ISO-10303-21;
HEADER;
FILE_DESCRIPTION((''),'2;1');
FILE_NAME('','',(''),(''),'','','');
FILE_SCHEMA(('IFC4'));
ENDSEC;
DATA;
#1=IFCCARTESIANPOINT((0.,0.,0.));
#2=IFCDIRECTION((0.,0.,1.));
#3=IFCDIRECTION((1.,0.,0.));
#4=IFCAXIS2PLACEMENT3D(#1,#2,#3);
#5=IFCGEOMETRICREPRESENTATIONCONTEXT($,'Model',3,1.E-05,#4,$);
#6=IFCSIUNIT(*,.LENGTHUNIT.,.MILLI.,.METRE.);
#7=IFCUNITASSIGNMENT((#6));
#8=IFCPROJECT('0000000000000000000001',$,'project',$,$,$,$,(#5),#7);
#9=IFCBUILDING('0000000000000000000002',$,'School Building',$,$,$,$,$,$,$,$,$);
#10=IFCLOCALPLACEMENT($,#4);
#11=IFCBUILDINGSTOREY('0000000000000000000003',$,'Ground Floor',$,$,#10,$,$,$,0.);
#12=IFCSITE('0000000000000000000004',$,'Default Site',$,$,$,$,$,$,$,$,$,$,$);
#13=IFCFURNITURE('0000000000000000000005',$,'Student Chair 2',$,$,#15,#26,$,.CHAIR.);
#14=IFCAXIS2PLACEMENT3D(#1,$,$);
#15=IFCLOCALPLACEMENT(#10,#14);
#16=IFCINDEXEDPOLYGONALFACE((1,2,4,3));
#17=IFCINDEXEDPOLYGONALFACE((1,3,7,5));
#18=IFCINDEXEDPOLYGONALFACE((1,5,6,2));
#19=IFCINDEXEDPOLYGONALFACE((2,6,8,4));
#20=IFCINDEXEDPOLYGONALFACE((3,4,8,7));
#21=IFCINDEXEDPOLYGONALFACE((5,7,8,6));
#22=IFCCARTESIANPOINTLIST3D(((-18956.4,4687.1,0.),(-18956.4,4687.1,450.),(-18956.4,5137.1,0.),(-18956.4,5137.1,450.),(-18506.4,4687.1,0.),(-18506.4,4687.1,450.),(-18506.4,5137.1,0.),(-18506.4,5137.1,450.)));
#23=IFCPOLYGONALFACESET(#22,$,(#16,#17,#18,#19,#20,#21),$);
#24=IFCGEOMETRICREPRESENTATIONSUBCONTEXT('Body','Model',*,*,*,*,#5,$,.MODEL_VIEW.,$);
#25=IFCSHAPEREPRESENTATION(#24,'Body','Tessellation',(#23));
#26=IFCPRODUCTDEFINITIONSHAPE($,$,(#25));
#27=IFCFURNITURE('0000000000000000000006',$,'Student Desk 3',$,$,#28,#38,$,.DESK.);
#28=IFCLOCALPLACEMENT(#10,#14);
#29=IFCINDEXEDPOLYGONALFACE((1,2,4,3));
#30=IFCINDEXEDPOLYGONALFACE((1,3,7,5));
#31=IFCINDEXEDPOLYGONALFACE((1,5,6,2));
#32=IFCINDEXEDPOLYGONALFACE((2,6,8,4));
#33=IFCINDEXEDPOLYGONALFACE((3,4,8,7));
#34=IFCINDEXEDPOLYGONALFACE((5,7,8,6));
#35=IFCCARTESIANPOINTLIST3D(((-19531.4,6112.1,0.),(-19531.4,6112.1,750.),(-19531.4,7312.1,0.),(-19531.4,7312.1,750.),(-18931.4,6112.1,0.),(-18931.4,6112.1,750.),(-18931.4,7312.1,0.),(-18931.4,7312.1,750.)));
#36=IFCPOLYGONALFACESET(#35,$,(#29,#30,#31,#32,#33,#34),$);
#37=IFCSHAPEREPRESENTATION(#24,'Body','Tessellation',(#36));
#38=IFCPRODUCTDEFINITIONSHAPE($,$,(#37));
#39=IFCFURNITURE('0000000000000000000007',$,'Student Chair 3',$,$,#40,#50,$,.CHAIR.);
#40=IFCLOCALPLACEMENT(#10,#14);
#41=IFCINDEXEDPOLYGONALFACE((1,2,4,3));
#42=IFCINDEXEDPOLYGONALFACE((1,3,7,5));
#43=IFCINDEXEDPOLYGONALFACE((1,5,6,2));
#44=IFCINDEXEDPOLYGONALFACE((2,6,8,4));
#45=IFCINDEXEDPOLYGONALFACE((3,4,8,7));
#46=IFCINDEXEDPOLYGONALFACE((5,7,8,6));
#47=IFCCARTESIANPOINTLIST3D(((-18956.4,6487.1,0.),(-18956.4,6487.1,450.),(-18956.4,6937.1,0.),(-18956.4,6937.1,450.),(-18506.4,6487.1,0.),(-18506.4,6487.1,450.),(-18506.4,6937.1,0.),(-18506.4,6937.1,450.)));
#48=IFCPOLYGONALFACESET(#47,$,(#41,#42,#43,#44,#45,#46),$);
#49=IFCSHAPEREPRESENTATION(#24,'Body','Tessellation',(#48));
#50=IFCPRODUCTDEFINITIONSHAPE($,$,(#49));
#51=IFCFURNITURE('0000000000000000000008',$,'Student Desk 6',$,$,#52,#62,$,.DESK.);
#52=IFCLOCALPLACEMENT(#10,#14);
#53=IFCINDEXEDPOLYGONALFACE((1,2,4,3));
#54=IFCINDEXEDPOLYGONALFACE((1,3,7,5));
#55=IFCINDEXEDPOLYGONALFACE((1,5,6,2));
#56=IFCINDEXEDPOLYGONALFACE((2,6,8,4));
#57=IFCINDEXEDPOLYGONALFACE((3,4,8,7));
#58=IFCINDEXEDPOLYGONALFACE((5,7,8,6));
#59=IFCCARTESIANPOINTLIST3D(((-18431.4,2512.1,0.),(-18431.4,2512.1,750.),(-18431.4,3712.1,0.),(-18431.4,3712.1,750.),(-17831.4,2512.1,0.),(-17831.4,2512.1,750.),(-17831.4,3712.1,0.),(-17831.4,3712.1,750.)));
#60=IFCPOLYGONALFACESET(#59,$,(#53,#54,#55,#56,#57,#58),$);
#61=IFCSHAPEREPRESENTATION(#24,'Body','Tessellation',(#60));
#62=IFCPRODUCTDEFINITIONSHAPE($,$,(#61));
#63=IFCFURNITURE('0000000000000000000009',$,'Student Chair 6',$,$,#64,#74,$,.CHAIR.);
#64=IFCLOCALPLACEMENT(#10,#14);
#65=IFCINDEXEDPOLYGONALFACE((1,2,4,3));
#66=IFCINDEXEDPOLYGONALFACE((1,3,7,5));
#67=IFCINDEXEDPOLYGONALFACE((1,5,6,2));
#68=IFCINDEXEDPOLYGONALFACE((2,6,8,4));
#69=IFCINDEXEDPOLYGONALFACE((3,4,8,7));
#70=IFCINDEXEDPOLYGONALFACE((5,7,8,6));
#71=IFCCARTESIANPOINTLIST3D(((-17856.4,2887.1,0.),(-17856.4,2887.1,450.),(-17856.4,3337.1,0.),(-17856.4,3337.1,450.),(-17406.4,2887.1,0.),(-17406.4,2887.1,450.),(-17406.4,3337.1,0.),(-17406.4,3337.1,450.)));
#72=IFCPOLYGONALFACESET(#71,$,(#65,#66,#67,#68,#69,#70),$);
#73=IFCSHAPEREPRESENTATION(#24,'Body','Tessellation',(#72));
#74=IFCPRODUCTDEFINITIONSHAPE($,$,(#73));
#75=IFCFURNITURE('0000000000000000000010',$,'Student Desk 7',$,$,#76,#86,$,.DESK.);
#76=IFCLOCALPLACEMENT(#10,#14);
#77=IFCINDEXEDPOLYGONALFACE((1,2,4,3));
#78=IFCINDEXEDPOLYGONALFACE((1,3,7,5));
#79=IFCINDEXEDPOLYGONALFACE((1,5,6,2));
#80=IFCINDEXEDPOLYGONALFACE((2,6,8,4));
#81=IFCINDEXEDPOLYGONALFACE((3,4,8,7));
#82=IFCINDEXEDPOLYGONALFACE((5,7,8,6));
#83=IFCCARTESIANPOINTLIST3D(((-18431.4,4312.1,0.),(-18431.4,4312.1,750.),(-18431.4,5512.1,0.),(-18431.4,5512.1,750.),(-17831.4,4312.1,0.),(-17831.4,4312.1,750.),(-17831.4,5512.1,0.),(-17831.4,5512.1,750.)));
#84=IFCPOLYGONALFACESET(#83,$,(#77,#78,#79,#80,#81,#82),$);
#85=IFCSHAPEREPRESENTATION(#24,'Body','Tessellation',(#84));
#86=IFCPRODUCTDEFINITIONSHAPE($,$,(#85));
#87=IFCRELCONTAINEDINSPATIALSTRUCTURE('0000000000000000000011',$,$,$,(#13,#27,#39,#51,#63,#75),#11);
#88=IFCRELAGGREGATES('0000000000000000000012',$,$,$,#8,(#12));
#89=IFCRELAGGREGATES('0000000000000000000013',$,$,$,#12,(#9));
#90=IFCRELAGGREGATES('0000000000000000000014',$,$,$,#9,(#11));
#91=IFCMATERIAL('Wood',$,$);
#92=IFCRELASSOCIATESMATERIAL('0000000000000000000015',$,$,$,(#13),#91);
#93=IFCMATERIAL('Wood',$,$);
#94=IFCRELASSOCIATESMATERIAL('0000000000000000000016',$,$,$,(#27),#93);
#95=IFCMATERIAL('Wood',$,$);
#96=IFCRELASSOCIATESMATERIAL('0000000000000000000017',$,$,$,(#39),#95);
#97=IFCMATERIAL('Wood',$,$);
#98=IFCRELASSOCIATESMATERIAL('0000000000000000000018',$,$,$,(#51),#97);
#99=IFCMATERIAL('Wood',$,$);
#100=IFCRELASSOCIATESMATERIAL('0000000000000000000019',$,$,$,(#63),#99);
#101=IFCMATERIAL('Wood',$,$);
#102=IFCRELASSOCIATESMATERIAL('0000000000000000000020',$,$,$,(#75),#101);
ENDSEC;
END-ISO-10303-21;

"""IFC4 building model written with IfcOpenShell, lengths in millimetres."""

from ifc_helpers import new_model, si_unit, frame, origin_with_axes, origin_2d, place, context, subcontext, project, spatial, rectangle, extrude, material, element, save


model = new_model("IFC4")

# Units and contexts
model_context = context("Model", 3, precision=1e-05, world=origin_with_axes())
body_context = subcontext(model_context, "Body", "Model", "MODEL_VIEW")
ifc_project = project(units=[si_unit("LENGTHUNIT", "METRE", prefix="MILLI")], contexts=[model_context])

# Site, building, storey
site = spatial("IfcSite", under=ifc_project, Name="Default Site")
building = spatial("IfcBuilding", under=site, Name="School Building")
storey_placement = place(None, origin_with_axes())
storey = spatial("IfcBuildingStorey", under=building, at=storey_placement, Name="Ground Floor", Elevation=0.0)

# Furniture
ifc_material_1 = material(Name="Wood")
furniture_1_placement = place(storey_placement, frame((-18731.4, 4912.1, 0.0), z_axis=(0.0, 0.0, 1.0), x_axis=(1.0, 0.0, 0.0)))
element("IfcFurniture", 1, at=furniture_1_placement, inside=storey, material=ifc_material_1, Name="Student Chair 2", PredefinedType="CHAIR", context=body_context, shape_type="SweptSolid", body=[
    extrude(rectangle(XDim=450.0, YDim=450.0, at=origin_2d()), origin_with_axes(), (0.0, 0.0, 1.0), 450.0),
])
ifc_material_2 = material(Name="Wood")
furniture_2_placement = place(storey_placement, frame((-19231.4, 6712.1, 0.0), z_axis=(0.0, 0.0, 1.0), x_axis=(0.0, 1.0, 0.0)))
element("IfcFurniture", 2, at=furniture_2_placement, inside=storey, material=ifc_material_2, Name="Student Desk 3", PredefinedType="DESK", context=body_context, shape_type="SweptSolid", body=[
    extrude(rectangle(XDim=1200.0, YDim=600.0, at=origin_2d()), origin_with_axes(), (0.0, 0.0, 1.0), 750.0),
])
ifc_material_3 = material(Name="Wood")
furniture_3_placement = place(storey_placement, frame((-18731.4, 6712.1, 0.0), z_axis=(0.0, 0.0, 1.0), x_axis=(1.0, 0.0, 0.0)))
element("IfcFurniture", 3, at=furniture_3_placement, inside=storey, material=ifc_material_3, Name="Student Chair 3", PredefinedType="CHAIR", context=body_context, shape_type="SweptSolid", body=[
    extrude(rectangle(XDim=450.0, YDim=450.0, at=origin_2d()), origin_with_axes(), (0.0, 0.0, 1.0), 450.0),
])
ifc_material_4 = material(Name="Wood")
furniture_4_placement = place(storey_placement, frame((-18131.4, 3112.1, 0.0), z_axis=(0.0, 0.0, 1.0), x_axis=(0.0, 1.0, 0.0)))
element("IfcFurniture", 4, at=furniture_4_placement, inside=storey, material=ifc_material_4, Name="Student Desk 6", PredefinedType="DESK", context=body_context, shape_type="SweptSolid", body=[
    extrude(rectangle(XDim=1200.0, YDim=600.0, at=origin_2d()), origin_with_axes(), (0.0, 0.0, 1.0), 750.0),
])
ifc_material_5 = material(Name="Wood")
furniture_5_placement = place(storey_placement, frame((-17631.4, 3112.1, 0.0), z_axis=(0.0, 0.0, 1.0), x_axis=(1.0, 0.0, 0.0)))
element("IfcFurniture", 5, at=furniture_5_placement, inside=storey, material=ifc_material_5, Name="Student Chair 6", PredefinedType="CHAIR", context=body_context, shape_type="SweptSolid", body=[
    extrude(rectangle(XDim=450.0, YDim=450.0, at=origin_2d()), origin_with_axes(), (0.0, 0.0, 1.0), 450.0),
])
ifc_material_6 = material(Name="Wood")
furniture_6_placement = place(storey_placement, frame((-18131.4, 4912.1, 0.0), z_axis=(0.0, 0.0, 1.0), x_axis=(0.0, 1.0, 0.0)))
element("IfcFurniture", 6, at=furniture_6_placement, inside=storey, material=ifc_material_6, Name="Student Desk 7", PredefinedType="DESK", context=body_context, shape_type="SweptSolid", body=[
    extrude(rectangle(XDim=1200.0, YDim=600.0, at=origin_2d()), origin_with_axes(), (0.0, 0.0, 1.0), 750.0),
])

save(model, "model.ifc")
